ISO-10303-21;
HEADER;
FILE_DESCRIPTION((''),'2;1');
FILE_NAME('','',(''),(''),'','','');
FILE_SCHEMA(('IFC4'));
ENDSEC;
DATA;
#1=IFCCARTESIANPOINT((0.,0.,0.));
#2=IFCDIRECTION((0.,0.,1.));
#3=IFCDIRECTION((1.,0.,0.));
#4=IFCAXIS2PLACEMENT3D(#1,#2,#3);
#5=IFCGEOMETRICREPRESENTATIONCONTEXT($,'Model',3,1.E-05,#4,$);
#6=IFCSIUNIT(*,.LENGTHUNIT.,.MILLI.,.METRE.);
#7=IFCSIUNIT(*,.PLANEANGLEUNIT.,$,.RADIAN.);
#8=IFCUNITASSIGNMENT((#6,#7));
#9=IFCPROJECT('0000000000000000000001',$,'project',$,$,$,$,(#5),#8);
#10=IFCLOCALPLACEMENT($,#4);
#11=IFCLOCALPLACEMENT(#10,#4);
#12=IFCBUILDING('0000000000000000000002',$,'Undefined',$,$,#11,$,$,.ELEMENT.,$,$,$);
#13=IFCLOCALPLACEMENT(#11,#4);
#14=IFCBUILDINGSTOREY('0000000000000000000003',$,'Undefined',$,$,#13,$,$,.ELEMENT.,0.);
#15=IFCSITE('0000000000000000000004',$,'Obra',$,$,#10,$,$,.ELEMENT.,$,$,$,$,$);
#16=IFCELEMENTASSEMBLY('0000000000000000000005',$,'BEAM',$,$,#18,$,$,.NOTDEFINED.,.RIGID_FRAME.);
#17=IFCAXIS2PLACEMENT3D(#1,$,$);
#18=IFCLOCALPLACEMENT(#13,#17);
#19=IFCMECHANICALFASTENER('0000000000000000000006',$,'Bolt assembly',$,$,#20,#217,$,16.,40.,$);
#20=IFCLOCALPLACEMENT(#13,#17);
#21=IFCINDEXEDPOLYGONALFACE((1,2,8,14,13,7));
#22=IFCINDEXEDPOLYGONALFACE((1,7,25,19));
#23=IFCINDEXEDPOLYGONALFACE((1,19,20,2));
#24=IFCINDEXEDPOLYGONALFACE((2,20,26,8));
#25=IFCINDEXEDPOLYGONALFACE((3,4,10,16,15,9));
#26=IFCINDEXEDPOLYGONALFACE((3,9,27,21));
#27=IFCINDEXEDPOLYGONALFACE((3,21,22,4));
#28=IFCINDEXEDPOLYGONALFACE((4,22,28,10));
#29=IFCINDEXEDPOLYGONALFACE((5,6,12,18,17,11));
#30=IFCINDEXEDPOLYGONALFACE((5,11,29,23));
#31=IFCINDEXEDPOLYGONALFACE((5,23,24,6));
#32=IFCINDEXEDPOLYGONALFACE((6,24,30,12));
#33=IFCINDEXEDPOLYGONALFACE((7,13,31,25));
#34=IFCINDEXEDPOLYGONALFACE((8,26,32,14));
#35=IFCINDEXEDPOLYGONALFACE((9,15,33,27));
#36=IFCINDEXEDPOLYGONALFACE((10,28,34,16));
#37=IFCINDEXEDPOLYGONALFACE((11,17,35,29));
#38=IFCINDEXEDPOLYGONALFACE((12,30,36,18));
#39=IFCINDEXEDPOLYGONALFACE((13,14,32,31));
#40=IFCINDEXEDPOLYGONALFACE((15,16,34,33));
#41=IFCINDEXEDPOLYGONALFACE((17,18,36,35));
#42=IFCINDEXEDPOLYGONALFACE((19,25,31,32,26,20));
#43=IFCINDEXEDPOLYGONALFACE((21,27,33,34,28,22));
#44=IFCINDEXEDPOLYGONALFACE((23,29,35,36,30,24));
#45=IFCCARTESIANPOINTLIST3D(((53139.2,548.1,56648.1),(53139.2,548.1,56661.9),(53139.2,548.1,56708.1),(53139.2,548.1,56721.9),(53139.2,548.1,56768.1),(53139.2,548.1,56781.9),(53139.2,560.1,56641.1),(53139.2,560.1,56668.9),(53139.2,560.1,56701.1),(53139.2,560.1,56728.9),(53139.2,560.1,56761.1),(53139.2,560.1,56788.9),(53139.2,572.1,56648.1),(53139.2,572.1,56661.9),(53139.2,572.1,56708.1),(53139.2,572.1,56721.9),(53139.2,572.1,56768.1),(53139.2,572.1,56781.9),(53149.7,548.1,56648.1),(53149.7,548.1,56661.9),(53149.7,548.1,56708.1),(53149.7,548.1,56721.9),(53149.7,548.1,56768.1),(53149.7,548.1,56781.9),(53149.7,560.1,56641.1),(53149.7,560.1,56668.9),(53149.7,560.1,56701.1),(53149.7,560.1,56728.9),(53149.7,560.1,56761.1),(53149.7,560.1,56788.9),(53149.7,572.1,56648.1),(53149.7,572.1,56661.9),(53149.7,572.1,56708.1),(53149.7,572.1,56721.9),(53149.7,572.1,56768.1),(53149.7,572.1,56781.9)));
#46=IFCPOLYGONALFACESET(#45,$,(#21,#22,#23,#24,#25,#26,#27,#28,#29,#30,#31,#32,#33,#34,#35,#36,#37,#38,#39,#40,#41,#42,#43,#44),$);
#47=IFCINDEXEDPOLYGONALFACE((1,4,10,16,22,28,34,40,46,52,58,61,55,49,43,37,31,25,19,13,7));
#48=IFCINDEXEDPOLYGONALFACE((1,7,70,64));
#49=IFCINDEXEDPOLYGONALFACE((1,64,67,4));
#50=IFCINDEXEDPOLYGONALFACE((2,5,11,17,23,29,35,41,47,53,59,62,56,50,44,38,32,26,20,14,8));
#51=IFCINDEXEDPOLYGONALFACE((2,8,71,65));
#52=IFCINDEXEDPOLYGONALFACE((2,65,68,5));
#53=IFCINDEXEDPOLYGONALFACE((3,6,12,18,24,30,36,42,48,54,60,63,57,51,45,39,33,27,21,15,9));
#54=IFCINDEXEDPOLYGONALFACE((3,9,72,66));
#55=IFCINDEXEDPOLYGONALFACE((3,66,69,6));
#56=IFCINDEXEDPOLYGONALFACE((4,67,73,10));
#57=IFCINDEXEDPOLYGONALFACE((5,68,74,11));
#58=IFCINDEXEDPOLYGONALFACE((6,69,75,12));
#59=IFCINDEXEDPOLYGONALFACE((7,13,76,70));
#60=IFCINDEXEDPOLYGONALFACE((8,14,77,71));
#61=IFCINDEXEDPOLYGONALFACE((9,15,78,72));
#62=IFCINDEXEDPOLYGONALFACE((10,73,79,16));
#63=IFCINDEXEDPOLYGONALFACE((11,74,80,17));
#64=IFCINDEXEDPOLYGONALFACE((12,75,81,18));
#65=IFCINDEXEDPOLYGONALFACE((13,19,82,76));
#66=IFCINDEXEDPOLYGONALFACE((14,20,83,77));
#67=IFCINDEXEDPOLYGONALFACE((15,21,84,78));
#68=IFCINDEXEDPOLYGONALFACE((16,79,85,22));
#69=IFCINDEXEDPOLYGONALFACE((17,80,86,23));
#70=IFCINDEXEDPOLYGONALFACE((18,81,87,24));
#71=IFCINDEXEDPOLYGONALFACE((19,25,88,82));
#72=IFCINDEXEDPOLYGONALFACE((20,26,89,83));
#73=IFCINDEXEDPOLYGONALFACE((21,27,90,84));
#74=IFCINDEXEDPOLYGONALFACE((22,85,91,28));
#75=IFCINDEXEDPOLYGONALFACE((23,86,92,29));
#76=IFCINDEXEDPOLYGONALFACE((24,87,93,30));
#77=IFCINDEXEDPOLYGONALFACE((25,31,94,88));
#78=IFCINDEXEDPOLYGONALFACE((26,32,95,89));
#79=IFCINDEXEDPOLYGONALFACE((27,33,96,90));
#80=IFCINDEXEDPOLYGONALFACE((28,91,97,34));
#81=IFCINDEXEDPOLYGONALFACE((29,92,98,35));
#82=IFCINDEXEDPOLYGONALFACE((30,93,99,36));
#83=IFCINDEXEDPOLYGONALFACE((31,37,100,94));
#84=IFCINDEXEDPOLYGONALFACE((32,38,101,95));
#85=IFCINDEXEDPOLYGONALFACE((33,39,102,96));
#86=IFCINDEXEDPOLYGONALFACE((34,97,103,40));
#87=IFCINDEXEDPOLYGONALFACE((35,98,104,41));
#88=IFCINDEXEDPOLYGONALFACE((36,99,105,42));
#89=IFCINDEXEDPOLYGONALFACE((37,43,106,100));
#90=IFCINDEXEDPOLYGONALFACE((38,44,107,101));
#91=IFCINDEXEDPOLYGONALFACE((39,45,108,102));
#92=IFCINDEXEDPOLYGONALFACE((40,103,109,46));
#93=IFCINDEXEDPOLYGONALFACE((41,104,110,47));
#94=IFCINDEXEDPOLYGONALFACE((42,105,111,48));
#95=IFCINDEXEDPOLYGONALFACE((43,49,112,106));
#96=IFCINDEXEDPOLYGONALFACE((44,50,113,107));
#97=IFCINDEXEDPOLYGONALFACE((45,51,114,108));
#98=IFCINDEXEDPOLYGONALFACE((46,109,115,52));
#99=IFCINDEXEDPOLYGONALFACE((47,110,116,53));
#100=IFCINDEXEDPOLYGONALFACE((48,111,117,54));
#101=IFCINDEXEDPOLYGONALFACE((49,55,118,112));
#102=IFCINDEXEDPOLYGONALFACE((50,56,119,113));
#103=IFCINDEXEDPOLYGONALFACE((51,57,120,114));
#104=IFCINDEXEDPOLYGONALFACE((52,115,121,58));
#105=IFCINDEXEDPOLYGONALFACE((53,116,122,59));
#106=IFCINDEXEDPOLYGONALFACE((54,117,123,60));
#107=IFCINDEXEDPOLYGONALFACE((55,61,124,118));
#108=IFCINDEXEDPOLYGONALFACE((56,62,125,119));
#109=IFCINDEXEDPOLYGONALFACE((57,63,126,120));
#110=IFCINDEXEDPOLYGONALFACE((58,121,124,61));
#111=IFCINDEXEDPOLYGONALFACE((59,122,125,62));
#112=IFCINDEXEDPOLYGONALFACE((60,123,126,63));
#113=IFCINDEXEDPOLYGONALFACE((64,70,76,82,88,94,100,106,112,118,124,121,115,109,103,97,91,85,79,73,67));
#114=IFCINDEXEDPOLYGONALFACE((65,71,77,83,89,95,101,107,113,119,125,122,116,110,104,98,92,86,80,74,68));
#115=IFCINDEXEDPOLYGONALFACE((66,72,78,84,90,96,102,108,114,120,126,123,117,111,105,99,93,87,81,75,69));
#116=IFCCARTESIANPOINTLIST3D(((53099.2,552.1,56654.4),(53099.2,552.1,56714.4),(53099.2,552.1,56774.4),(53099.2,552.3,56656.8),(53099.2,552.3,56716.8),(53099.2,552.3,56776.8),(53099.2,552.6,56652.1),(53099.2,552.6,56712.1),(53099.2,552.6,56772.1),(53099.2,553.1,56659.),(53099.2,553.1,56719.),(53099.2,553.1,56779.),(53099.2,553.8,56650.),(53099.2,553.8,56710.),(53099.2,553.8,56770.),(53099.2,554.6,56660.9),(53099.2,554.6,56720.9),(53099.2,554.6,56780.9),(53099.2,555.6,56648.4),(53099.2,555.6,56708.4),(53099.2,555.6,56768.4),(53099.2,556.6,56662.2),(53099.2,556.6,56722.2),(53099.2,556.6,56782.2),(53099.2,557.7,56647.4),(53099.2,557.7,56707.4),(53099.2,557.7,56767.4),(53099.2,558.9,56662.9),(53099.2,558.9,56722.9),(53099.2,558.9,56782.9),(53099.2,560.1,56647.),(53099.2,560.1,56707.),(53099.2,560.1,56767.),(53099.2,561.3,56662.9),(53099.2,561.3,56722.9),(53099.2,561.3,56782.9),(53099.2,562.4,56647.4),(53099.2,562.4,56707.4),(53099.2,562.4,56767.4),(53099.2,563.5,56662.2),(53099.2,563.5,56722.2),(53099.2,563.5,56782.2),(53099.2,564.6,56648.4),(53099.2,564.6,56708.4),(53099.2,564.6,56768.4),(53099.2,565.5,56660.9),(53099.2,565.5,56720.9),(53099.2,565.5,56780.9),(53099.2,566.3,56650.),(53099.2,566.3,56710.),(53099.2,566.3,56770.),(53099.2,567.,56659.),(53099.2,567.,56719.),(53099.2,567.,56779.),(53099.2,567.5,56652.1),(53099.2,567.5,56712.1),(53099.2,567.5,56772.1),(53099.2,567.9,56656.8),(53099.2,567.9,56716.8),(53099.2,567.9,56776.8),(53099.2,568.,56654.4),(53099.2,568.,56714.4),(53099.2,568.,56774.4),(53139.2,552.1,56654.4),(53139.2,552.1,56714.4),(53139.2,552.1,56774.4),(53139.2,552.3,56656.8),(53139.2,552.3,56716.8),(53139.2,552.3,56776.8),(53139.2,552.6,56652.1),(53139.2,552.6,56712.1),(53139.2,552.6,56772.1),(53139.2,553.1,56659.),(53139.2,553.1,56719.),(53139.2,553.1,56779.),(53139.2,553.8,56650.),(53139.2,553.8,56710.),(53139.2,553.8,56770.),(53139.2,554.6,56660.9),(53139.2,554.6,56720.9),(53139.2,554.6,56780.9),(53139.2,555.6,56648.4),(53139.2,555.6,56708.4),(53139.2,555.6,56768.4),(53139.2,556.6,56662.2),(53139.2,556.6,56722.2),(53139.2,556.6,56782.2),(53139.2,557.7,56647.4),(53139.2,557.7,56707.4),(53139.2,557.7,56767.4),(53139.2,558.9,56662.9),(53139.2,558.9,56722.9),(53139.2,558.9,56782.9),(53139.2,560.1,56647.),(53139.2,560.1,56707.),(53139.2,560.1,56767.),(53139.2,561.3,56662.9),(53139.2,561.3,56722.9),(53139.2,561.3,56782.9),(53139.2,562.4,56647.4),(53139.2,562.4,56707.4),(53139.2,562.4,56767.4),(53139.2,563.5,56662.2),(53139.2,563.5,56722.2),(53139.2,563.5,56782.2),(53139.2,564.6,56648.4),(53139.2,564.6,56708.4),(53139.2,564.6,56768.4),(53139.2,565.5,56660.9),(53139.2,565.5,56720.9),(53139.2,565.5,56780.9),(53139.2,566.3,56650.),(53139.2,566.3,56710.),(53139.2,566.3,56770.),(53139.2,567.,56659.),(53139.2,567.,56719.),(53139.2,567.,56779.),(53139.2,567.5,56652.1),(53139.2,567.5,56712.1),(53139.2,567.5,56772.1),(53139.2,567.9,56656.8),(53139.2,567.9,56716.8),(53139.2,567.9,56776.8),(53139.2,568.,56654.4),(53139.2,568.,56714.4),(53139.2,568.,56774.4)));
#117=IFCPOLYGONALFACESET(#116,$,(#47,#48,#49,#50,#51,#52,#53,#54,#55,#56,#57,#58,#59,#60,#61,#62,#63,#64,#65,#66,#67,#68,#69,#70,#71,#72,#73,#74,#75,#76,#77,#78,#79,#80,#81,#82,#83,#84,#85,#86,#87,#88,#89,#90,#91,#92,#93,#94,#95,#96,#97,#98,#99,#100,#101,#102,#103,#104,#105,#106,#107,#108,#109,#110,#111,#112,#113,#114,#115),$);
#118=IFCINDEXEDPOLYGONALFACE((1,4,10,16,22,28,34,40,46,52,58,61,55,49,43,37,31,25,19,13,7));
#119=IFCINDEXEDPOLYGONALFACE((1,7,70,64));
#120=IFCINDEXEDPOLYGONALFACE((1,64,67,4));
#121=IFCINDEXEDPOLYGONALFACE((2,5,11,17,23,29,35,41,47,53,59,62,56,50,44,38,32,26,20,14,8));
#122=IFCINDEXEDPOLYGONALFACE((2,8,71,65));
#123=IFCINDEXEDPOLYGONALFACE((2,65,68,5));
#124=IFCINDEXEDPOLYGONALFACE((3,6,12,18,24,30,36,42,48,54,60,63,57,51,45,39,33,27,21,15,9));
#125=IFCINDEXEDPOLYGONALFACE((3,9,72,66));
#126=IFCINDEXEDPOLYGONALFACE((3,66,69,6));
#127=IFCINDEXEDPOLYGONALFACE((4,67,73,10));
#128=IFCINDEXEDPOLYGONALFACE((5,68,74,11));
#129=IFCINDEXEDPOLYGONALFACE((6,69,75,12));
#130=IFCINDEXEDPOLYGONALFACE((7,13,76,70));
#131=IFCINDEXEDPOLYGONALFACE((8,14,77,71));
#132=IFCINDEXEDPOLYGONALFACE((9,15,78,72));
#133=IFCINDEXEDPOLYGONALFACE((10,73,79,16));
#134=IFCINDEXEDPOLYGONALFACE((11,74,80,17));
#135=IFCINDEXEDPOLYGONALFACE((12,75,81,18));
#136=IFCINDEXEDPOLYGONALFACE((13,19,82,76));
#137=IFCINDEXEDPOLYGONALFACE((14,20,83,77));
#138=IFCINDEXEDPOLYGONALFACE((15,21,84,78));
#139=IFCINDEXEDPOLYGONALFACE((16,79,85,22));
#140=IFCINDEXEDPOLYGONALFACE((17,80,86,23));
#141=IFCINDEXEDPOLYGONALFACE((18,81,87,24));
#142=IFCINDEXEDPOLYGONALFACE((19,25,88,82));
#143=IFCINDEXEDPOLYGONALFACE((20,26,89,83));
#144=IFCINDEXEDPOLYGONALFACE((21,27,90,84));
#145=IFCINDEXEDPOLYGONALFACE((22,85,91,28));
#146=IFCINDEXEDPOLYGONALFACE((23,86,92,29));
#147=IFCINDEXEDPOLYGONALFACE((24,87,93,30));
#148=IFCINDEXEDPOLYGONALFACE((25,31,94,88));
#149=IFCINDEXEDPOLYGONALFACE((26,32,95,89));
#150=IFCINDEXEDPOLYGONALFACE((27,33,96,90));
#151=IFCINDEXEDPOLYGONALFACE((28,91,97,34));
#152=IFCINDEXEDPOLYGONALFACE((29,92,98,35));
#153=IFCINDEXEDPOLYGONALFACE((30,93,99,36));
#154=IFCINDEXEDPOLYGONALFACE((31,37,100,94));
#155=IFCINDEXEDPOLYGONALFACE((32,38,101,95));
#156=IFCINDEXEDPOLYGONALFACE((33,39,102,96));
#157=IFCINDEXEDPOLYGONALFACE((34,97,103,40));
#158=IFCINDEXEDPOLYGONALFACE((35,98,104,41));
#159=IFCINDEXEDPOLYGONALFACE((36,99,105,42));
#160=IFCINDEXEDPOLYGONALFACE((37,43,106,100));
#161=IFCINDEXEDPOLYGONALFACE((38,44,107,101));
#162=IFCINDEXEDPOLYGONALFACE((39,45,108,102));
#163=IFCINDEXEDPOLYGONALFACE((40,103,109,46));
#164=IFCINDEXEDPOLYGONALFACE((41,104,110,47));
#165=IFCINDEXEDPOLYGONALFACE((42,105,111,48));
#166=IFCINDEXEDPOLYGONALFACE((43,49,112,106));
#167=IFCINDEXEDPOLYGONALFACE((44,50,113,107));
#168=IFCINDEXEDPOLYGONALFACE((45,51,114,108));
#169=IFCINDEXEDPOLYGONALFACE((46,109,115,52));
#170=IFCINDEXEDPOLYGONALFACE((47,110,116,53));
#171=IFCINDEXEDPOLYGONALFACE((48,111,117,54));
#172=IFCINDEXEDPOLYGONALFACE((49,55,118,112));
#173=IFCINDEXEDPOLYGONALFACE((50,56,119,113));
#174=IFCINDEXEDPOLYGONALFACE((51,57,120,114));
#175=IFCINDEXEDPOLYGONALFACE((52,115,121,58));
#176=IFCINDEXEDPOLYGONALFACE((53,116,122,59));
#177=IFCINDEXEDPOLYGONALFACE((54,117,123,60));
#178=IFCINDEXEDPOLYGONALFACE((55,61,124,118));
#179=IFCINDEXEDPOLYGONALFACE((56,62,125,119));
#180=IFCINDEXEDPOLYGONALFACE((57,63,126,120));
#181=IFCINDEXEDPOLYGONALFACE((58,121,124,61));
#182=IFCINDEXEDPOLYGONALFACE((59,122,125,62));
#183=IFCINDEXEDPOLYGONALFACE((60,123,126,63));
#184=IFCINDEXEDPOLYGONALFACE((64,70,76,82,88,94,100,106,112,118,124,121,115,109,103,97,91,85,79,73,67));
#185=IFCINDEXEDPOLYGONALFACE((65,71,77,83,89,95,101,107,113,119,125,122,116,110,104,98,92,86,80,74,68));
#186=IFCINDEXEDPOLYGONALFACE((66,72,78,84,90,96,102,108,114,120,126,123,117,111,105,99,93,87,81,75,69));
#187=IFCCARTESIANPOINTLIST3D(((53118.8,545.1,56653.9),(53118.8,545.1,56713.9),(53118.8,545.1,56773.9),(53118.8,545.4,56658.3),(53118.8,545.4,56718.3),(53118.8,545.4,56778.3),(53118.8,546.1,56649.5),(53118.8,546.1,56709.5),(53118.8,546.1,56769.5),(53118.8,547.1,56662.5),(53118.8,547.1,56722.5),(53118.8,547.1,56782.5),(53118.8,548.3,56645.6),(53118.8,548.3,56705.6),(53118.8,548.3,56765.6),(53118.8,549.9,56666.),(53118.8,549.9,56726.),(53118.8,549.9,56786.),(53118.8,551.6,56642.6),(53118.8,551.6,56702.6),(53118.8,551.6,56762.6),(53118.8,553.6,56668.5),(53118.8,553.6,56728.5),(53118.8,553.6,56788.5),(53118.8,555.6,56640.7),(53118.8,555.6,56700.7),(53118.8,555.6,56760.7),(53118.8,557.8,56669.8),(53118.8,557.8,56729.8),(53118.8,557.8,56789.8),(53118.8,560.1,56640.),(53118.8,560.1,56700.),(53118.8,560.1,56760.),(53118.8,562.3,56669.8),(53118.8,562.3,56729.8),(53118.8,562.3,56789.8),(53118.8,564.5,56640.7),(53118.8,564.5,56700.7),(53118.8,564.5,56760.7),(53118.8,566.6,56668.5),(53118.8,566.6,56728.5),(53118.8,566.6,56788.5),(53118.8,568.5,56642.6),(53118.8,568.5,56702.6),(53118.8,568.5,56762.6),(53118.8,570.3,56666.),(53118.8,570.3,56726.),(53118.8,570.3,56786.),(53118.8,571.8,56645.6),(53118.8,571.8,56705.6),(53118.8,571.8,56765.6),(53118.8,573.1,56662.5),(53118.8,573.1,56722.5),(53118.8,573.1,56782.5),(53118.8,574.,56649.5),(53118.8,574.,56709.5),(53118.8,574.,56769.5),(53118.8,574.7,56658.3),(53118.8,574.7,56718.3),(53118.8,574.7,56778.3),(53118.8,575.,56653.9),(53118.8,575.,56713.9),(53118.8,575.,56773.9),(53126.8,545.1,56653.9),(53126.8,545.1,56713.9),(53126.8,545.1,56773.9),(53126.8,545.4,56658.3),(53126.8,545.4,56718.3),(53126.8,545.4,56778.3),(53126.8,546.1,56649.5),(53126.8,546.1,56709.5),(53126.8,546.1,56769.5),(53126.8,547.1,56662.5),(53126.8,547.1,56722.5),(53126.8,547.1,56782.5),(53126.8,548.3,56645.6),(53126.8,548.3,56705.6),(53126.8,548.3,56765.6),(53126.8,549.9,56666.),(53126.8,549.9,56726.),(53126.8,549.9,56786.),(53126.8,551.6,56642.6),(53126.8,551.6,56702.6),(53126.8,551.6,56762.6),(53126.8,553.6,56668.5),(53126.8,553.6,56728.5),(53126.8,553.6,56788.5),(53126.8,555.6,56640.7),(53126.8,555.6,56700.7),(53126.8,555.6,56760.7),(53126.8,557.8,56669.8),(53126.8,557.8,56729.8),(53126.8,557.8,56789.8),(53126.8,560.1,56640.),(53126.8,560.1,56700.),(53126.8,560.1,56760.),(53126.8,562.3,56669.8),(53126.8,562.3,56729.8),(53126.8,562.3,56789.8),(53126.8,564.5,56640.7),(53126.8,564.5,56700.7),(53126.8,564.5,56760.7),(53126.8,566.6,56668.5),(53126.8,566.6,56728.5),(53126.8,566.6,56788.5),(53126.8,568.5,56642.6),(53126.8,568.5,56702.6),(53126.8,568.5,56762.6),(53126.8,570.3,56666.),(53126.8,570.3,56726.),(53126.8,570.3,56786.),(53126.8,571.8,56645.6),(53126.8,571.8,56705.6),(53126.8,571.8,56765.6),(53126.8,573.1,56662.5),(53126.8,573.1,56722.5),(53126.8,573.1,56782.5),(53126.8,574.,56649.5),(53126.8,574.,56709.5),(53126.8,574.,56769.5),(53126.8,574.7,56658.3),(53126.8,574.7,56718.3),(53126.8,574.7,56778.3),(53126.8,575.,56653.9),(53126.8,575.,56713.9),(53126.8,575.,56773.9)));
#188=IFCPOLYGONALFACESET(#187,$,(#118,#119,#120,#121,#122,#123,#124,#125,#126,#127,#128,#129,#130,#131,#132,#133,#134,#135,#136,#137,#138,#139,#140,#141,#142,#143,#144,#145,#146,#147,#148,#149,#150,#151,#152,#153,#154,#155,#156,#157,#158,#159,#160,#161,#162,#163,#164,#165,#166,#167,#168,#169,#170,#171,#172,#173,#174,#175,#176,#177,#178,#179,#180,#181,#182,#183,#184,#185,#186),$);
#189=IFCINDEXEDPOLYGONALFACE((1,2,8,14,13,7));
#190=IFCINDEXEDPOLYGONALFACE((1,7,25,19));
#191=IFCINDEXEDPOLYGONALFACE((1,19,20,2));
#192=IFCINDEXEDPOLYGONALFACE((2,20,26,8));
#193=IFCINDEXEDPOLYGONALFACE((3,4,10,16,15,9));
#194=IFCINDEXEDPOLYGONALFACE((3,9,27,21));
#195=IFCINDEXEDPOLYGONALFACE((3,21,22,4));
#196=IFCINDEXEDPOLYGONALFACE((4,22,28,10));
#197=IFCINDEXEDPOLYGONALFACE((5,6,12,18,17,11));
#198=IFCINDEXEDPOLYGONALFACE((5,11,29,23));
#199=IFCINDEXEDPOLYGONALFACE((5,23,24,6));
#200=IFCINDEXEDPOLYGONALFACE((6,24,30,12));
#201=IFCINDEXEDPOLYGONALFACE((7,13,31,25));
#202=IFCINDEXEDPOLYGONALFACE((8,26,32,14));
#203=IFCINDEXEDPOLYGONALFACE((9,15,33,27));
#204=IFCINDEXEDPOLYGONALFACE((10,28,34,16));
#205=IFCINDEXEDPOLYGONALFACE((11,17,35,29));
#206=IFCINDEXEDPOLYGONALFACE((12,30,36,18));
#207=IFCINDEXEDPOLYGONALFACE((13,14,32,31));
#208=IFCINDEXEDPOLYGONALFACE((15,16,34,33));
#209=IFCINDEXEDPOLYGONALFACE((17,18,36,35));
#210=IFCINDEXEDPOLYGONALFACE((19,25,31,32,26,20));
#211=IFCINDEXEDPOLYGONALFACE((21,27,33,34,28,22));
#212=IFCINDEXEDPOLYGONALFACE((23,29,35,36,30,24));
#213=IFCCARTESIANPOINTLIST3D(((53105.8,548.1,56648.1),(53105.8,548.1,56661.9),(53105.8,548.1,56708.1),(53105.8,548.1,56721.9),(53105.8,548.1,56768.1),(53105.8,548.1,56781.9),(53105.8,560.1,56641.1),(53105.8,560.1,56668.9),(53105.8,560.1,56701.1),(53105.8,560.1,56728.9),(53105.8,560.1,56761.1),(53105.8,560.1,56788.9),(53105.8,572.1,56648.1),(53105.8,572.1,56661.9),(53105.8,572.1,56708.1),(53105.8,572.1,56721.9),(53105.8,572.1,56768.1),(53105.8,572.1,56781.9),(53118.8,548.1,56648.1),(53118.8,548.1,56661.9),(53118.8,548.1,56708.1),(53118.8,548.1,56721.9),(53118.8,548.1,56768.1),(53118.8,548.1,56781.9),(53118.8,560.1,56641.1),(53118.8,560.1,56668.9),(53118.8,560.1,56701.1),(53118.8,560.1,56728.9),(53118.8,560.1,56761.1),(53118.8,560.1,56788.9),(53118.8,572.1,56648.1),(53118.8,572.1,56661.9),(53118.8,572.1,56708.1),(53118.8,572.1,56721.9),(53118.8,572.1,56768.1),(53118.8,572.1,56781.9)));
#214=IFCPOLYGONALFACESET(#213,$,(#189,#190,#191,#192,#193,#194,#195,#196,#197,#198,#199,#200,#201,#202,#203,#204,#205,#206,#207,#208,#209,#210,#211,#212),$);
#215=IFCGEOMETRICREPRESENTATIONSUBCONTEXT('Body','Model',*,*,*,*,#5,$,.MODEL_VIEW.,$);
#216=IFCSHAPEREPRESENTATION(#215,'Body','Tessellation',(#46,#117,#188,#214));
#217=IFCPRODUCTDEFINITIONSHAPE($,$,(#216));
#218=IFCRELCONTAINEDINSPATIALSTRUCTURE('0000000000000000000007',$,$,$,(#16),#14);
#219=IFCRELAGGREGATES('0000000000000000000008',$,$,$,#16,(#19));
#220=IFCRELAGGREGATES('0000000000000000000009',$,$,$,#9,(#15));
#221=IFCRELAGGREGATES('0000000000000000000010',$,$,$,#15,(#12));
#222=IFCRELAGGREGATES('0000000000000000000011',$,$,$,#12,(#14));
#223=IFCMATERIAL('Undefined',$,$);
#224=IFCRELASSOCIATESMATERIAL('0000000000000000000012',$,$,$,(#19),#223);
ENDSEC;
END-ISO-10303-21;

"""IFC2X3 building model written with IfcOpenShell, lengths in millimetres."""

from ifc_helpers import new_model, si_unit, frame, origin_with_axes, origin_2d_with_axis, place, context, subcontext, project, spatial, polyline, circle, outline, extrude, source, transform, mapped, material, element, aggregate, save


model = new_model("IFC2X3")

# Units and contexts
model_context = context("Model", 3, precision=1e-05, world=origin_with_axes())
body_context = subcontext(model_context, "Body", "Model", "MODEL_VIEW")
ifc_project = project(units=[si_unit("LENGTHUNIT", "METRE", prefix="MILLI"), si_unit("PLANEANGLEUNIT", "RADIAN")], contexts=[model_context])

# Site, building, storey
site_placement = place(None, origin_with_axes())
site = spatial("IfcSite", under=ifc_project, at=site_placement, Name="Obra", CompositionType="ELEMENT")
building_placement = place(site_placement, origin_with_axes())
building = spatial("IfcBuilding", under=site, at=building_placement, Name="Undefined", CompositionType="ELEMENT")
storey_placement = place(building_placement, origin_with_axes())
storey = spatial("IfcBuildingStorey", under=building, at=storey_placement, Name="Undefined", CompositionType="ELEMENT", Elevation=0.0)

# Element assembly, mechanical fastener
assembly_1_placement = place(storey_placement, origin_with_axes())
assembly_1 = element("IfcElementAssembly", 1, at=assembly_1_placement, inside=storey, Name="BEAM", AssemblyPlace="NOTDEFINED", PredefinedType="RIGID_FRAME")
ifc_material_1 = material(Name="Undefined")
shared_shape_1 = source(origin_with_axes(), body_context, "Body", "SweptSolid", [
    extrude(outline(polyline([(13.9, 0.0), (6.9, 12.0), (-6.9, 12.0), (-13.9, 0.0), (-6.9, -12.0), (6.9, -12.0), (13.9, 0.0)])), frame((0.0, -19.7, 0.0), z_axis=(0.0, 1.0, 0.0), x_axis=(1.0, 0.0, 0.0)), (0.0, 0.0, 1.0), 10.6),
    extrude(circle(Radius=8.0, at=origin_2d_with_axis()), frame((0.0, -9.1, 0.0), z_axis=(0.0, 1.0, 0.0), x_axis=(1.0, 0.0, 0.0)), (0.0, 0.0, 1.0), 40.0),
    extrude(circle(Radius=15.0, at=origin_2d_with_axis()), frame((0.0, 3.3, 0.0), z_axis=(0.0, 1.0, 0.0), x_axis=(1.0, 0.0, 0.0)), (0.0, 0.0, 1.0), 8.0),
    extrude(outline(polyline([(13.9, 0.0), (6.9, 12.0), (-6.9, 12.0), (-13.9, 0.0), (-6.9, -12.0), (6.9, -12.0), (13.9, 0.0)])), frame((0.0, 11.3, 0.0), z_axis=(0.0, 1.0, 0.0), x_axis=(1.0, 0.0, 0.0)), (0.0, 0.0, 1.0), 13.0),
])
mechanical_fastener_1_placement = place(assembly_1_placement, frame((53130.1, 510.1, 56835.0), z_axis=(-0.000002, 1.0, 0.0), x_axis=(0.0, 0.0, -1.0)))
mechanical_fastener_1 = element("IfcMechanicalFastener", 2, at=mechanical_fastener_1_placement, material=ifc_material_1, Name="Bolt assembly", NominalDiameter=16.0, NominalLength=40.0, context=body_context, shape_type="MappedRepresentation", body=[
    mapped(shared_shape_1, transform((60.0, 0.0, 50.0))),
    mapped(shared_shape_1, transform((120.0, 0.0, 50.0))),
    mapped(shared_shape_1, transform((180.0, 0.0, 50.0))),
])
aggregate(assembly_1, [mechanical_fastener_1])

save(model, "model.ifc")
